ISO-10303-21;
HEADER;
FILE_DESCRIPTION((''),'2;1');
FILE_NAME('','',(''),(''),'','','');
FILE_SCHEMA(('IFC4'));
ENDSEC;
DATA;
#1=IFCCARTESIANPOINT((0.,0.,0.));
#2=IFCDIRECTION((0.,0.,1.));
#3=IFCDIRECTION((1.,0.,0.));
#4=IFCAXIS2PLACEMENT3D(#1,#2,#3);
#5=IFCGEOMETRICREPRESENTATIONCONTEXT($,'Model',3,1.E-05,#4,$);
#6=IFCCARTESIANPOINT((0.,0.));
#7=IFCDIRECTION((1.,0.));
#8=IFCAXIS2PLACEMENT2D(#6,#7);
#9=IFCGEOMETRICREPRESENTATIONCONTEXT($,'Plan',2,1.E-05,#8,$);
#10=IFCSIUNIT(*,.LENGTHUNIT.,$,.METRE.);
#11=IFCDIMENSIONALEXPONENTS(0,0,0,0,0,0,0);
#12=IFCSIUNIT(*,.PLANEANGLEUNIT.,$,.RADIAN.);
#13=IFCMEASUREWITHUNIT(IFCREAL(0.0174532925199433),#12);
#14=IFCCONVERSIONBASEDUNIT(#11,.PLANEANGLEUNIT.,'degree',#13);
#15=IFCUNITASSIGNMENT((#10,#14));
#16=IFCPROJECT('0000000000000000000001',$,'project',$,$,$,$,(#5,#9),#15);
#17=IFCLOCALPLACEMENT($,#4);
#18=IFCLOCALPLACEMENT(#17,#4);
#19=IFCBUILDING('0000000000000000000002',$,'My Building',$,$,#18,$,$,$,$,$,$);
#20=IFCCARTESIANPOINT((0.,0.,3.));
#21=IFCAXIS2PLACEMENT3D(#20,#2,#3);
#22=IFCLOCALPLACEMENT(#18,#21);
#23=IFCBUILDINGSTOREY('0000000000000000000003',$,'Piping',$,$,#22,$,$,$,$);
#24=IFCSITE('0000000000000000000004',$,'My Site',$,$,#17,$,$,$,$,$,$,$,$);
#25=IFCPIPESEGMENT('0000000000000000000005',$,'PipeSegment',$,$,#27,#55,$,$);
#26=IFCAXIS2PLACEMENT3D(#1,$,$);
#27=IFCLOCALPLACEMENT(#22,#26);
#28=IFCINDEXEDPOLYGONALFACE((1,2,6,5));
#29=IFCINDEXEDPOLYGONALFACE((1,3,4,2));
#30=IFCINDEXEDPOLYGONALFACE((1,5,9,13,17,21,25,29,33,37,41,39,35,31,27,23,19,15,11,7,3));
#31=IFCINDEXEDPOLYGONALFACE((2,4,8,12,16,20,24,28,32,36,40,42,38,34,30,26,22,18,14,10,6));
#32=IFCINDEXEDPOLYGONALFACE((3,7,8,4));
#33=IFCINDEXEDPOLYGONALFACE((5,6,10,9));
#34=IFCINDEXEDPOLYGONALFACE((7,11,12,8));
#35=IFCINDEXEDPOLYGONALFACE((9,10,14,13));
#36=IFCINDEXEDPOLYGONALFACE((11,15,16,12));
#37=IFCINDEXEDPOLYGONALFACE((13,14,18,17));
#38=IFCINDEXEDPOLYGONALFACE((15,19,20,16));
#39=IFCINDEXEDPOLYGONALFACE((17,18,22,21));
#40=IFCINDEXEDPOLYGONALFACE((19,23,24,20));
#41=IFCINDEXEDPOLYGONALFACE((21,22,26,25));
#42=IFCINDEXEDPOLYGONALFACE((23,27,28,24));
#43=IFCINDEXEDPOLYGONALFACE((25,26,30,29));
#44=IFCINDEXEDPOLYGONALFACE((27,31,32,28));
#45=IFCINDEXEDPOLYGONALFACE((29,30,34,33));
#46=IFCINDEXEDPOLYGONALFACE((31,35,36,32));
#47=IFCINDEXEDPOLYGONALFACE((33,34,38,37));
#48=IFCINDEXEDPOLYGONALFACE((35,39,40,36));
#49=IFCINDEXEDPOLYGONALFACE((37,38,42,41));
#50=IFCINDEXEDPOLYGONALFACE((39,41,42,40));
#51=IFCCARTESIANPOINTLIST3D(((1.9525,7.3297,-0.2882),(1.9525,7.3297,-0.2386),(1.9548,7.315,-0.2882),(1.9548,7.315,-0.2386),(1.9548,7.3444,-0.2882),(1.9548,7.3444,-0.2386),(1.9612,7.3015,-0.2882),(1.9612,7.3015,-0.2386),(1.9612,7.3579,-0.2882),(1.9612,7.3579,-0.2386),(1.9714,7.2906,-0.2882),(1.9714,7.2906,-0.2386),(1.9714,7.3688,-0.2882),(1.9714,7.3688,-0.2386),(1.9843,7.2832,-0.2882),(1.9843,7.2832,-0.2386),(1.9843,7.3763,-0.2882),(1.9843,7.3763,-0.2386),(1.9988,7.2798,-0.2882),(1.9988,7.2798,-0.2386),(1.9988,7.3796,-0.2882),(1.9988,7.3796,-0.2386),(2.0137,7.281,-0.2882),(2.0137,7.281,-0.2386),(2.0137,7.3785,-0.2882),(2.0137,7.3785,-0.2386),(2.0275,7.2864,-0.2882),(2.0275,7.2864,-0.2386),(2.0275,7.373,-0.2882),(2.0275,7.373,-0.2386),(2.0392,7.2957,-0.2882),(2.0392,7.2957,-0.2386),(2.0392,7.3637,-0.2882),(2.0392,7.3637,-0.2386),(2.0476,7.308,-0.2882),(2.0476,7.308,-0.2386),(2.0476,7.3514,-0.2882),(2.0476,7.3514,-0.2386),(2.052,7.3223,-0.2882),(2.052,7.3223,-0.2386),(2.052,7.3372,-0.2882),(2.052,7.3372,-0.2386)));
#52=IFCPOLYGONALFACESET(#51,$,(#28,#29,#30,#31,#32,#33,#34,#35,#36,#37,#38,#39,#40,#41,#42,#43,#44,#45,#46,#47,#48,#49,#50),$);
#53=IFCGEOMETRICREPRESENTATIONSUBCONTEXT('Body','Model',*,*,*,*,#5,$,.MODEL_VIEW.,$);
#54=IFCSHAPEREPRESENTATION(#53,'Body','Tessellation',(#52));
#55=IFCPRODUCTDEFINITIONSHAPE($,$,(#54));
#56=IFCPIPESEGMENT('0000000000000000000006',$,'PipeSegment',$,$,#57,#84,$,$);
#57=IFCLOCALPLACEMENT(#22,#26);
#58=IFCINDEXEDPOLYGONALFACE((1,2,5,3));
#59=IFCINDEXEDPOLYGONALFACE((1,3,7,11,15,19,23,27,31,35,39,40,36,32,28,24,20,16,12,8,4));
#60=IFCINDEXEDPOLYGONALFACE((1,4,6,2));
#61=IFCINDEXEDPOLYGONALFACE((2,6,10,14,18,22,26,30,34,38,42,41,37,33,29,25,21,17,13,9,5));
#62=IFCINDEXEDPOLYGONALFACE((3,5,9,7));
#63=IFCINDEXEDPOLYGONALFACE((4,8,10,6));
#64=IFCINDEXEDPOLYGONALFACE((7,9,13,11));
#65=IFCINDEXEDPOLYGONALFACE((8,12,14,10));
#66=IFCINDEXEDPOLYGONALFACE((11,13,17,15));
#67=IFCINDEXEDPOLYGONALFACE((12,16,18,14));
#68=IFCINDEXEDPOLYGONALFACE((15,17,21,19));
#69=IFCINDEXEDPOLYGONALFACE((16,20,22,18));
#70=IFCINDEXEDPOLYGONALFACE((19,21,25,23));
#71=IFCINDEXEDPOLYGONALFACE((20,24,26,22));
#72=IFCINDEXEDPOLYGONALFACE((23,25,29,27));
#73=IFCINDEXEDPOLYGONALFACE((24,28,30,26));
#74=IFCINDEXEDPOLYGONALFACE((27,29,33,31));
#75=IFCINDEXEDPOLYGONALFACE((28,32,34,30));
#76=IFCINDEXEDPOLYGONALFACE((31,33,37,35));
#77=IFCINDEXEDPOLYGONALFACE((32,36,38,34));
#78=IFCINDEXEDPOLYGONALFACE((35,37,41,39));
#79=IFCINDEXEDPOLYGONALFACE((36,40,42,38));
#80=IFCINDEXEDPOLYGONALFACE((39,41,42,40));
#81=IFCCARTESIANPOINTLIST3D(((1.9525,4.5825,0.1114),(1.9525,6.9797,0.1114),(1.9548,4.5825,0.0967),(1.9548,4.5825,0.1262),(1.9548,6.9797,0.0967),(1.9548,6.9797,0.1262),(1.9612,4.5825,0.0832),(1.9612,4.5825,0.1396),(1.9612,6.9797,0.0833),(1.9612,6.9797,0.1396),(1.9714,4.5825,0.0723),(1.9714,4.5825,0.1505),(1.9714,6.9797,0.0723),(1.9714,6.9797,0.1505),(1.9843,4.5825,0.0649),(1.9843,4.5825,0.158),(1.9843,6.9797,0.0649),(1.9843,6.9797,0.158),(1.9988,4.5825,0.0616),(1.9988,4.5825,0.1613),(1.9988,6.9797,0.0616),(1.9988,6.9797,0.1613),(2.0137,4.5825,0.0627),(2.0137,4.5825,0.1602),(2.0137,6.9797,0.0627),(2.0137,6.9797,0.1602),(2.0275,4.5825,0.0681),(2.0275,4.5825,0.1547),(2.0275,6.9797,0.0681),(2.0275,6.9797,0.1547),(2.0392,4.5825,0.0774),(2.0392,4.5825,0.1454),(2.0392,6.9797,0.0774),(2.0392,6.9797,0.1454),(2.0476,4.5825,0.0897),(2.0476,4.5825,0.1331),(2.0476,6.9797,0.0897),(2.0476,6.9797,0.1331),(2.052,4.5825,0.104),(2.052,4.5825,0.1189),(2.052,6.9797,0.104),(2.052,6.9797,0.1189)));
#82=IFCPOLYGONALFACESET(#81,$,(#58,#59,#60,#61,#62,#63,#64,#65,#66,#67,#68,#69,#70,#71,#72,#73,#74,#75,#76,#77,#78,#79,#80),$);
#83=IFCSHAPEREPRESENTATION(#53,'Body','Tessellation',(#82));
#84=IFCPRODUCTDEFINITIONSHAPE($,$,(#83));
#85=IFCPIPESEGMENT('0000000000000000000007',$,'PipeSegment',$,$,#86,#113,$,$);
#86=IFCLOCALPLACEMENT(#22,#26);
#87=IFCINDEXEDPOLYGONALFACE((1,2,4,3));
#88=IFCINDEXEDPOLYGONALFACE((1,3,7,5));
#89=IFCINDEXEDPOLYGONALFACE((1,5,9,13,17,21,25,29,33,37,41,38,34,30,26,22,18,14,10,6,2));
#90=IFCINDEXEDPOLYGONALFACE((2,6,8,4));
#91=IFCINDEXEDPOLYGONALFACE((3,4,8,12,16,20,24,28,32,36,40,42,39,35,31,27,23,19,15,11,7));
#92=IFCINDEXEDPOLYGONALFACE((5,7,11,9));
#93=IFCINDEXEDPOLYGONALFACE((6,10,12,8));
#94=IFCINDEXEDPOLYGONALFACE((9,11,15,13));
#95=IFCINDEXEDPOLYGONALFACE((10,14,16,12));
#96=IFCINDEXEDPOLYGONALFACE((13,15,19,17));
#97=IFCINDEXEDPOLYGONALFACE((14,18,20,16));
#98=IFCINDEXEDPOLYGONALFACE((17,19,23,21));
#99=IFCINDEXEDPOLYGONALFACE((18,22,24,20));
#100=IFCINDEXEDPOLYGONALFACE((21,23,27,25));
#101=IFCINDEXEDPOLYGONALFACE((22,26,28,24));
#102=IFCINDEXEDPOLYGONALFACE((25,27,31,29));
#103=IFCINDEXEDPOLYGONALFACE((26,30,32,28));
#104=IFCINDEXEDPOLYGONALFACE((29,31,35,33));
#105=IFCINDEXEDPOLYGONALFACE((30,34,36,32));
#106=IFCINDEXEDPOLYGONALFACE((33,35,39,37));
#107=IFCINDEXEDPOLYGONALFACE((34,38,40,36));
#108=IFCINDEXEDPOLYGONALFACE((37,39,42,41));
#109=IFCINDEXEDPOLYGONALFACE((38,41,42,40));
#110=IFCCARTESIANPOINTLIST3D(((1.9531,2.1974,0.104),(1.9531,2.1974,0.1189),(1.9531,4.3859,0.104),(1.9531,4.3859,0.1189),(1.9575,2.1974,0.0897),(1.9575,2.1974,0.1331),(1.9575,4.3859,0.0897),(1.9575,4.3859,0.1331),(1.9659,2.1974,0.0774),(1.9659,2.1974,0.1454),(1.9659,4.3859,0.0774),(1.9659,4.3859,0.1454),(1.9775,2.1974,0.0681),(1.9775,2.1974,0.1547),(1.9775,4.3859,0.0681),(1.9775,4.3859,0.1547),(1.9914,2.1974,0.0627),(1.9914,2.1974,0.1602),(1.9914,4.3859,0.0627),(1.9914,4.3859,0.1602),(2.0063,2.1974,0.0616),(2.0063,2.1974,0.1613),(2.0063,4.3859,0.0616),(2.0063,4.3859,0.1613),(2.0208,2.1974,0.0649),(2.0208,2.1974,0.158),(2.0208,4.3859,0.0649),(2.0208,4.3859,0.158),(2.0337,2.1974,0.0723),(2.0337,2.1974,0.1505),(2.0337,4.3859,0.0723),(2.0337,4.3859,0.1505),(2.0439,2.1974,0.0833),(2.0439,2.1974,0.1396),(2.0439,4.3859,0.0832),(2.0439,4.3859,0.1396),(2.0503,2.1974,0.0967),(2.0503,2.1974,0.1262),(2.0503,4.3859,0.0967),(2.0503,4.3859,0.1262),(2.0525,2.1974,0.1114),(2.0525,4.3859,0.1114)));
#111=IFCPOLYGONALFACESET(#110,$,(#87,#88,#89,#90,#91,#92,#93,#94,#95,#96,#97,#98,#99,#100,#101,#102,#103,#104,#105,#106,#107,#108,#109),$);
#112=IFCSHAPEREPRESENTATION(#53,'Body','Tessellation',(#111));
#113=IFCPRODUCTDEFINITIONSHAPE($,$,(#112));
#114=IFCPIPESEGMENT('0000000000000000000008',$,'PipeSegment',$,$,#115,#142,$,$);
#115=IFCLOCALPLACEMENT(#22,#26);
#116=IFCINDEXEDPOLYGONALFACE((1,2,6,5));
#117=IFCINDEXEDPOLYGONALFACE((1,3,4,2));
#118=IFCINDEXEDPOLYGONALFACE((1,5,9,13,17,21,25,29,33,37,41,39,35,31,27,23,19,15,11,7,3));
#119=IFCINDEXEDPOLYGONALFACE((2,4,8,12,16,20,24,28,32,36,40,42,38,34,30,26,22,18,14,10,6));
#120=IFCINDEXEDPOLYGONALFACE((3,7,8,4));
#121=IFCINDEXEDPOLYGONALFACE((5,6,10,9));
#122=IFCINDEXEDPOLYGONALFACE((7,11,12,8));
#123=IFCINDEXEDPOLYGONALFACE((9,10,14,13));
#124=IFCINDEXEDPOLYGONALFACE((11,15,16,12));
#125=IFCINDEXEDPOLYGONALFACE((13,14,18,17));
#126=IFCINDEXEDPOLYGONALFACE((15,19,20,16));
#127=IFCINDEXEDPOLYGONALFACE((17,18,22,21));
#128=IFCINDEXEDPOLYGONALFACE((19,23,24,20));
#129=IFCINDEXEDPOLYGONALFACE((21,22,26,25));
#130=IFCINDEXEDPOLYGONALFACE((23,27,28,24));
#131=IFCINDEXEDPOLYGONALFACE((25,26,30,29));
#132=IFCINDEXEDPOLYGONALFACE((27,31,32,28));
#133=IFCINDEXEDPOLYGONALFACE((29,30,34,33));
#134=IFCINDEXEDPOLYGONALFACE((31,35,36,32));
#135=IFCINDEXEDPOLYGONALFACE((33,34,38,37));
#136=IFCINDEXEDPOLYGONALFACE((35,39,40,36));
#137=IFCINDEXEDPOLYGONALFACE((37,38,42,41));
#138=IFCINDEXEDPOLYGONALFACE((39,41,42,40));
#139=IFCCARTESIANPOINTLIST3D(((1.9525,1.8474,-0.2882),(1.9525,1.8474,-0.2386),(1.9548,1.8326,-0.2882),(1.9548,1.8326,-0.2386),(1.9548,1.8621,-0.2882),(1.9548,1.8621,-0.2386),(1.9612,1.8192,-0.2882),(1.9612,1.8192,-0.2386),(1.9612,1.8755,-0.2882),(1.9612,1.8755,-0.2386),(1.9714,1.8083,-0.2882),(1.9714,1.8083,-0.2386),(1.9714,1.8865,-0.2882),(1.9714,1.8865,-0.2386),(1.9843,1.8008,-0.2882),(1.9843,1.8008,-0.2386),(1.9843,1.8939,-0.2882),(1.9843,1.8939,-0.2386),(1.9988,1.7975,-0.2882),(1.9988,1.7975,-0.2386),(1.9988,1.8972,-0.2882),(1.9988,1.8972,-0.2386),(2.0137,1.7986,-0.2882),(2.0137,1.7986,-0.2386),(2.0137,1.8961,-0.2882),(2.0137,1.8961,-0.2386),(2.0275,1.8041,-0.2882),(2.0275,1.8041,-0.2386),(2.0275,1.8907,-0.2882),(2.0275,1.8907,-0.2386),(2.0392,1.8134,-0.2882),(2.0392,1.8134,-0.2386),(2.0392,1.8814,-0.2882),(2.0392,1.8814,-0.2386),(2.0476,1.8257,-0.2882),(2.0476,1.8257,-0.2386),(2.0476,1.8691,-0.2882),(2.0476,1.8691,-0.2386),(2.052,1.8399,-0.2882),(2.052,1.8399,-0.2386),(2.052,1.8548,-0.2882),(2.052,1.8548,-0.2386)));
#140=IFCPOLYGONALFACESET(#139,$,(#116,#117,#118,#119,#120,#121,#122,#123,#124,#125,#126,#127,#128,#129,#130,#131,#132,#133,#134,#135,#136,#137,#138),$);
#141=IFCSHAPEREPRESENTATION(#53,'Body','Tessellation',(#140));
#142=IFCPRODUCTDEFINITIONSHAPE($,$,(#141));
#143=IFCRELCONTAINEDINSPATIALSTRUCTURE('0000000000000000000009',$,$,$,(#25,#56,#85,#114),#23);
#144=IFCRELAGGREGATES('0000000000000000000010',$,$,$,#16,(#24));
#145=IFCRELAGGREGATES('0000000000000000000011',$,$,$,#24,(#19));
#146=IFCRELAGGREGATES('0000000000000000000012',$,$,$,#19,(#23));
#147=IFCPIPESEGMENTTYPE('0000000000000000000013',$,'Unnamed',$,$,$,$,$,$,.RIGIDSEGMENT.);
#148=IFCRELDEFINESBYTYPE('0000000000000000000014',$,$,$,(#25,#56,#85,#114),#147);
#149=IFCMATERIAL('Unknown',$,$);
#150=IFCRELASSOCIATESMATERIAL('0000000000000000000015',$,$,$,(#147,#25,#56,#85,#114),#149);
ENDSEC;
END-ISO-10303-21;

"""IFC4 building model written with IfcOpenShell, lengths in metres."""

from ifc_helpers import new_model, entity, si_unit, converted_unit, frame, origin_with_axes, origin_2d_with_axis, place, context, subcontext, project, spatial, circle, extrude, material, material_profile, profile_set, profile_usage, type_object, element, save


model = new_model("IFC4")

# Units and contexts
model_context = context("Model", 3, precision=1e-05, world=origin_with_axes())
plan_context = context("Plan", 2, precision=1e-05, world=origin_2d_with_axis())
body_context = subcontext(model_context, "Body", "Model", "MODEL_VIEW")
ifc_project = project(units=[si_unit("LENGTHUNIT", "METRE"), converted_unit("PLANEANGLEUNIT", "degree", entity("IfcReal", 0.0174532925199433), si_unit("PLANEANGLEUNIT", "RADIAN"), dimensions=[0, 0, 0, 0, 0, 0, 0])], contexts=[model_context, plan_context])

# Site, building, storey
site_placement = place(None, origin_with_axes())
site = spatial("IfcSite", under=ifc_project, at=site_placement, Name="My Site")
building_placement = place(site_placement, origin_with_axes())
building = spatial("IfcBuilding", under=site, at=building_placement, Name="My Building")
storey_placement = place(building_placement, frame((0.0, 0.0, 3.0), z_axis=(0.0, 0.0, 1.0), x_axis=(1.0, 0.0, 0.0)))
storey = spatial("IfcBuildingStorey", under=building, at=storey_placement, Name="Piping")

# Pipe segments
ifc_material = material(Name="Unknown")
ifc_material_profile_1 = material_profile(ifc_material, circle(Radius=0.05))
ifc_profile_set_1 = profile_set([ifc_material_profile_1])
pipe_segment_type = type_object("IfcPipeSegmentType", Name="Unnamed", PredefinedType="RIGIDSEGMENT", material=ifc_profile_set_1)
ifc_profile_usage_1 = profile_usage(ifc_profile_set_1, cardinal=16)
pipe_segment_1_placement = place(storey_placement, frame((2.0025, 7.3297, -0.2386), z_axis=(0.0, 0.0, -1.0), x_axis=(-1.0, 0.0, 0.0)))
element("IfcPipeSegment", 1, at=pipe_segment_1_placement, inside=storey, type_object=pipe_segment_type, material=ifc_profile_usage_1, Name="PipeSegment", context=body_context, shape_type="SweptSolid", body=[
    extrude(circle(Radius=0.05), origin_with_axes(), (0.0, 0.0, 1.0), 0.0496),
])
ifc_profile_usage_2 = profile_usage(ifc_profile_set_1, cardinal=16)
pipe_segment_2_placement = place(storey_placement, frame((2.0025, 4.5825, 0.1114), z_axis=(0.0, 1.0, 0.0), x_axis=(-1.0, 0.0, 0.0)))
element("IfcPipeSegment", 2, at=pipe_segment_2_placement, inside=storey, type_object=pipe_segment_type, material=ifc_profile_usage_2, Name="PipeSegment", context=body_context, shape_type="SweptSolid", body=[
    extrude(circle(Radius=0.05), origin_with_axes(), (0.0, 0.0, 1.0), 2.3972),
])
ifc_profile_usage_3 = profile_usage(ifc_profile_set_1, cardinal=16)
pipe_segment_3_placement = place(storey_placement, frame((2.0025, 4.3859, 0.1114), z_axis=(0.0, -1.0, 0.0), x_axis=(1.0, 0.0, 0.0)))
element("IfcPipeSegment", 3, at=pipe_segment_3_placement, inside=storey, type_object=pipe_segment_type, material=ifc_profile_usage_3, Name="PipeSegment", context=body_context, shape_type="SweptSolid", body=[
    extrude(circle(Radius=0.05), origin_with_axes(), (0.0, 0.0, 1.0), 2.1885),
])
ifc_profile_usage_4 = profile_usage(ifc_profile_set_1, cardinal=16)
pipe_segment_4_placement = place(storey_placement, frame((2.0025, 1.8474, -0.2386), z_axis=(0.0, 0.0, -1.0), x_axis=(-1.0, 0.0, 0.0)))
element("IfcPipeSegment", 4, at=pipe_segment_4_placement, inside=storey, type_object=pipe_segment_type, material=ifc_profile_usage_4, Name="PipeSegment", context=body_context, shape_type="SweptSolid", body=[
    extrude(circle(Radius=0.05), origin_with_axes(), (0.0, 0.0, 1.0), 0.0496),
])

save(model, "model.ifc")
